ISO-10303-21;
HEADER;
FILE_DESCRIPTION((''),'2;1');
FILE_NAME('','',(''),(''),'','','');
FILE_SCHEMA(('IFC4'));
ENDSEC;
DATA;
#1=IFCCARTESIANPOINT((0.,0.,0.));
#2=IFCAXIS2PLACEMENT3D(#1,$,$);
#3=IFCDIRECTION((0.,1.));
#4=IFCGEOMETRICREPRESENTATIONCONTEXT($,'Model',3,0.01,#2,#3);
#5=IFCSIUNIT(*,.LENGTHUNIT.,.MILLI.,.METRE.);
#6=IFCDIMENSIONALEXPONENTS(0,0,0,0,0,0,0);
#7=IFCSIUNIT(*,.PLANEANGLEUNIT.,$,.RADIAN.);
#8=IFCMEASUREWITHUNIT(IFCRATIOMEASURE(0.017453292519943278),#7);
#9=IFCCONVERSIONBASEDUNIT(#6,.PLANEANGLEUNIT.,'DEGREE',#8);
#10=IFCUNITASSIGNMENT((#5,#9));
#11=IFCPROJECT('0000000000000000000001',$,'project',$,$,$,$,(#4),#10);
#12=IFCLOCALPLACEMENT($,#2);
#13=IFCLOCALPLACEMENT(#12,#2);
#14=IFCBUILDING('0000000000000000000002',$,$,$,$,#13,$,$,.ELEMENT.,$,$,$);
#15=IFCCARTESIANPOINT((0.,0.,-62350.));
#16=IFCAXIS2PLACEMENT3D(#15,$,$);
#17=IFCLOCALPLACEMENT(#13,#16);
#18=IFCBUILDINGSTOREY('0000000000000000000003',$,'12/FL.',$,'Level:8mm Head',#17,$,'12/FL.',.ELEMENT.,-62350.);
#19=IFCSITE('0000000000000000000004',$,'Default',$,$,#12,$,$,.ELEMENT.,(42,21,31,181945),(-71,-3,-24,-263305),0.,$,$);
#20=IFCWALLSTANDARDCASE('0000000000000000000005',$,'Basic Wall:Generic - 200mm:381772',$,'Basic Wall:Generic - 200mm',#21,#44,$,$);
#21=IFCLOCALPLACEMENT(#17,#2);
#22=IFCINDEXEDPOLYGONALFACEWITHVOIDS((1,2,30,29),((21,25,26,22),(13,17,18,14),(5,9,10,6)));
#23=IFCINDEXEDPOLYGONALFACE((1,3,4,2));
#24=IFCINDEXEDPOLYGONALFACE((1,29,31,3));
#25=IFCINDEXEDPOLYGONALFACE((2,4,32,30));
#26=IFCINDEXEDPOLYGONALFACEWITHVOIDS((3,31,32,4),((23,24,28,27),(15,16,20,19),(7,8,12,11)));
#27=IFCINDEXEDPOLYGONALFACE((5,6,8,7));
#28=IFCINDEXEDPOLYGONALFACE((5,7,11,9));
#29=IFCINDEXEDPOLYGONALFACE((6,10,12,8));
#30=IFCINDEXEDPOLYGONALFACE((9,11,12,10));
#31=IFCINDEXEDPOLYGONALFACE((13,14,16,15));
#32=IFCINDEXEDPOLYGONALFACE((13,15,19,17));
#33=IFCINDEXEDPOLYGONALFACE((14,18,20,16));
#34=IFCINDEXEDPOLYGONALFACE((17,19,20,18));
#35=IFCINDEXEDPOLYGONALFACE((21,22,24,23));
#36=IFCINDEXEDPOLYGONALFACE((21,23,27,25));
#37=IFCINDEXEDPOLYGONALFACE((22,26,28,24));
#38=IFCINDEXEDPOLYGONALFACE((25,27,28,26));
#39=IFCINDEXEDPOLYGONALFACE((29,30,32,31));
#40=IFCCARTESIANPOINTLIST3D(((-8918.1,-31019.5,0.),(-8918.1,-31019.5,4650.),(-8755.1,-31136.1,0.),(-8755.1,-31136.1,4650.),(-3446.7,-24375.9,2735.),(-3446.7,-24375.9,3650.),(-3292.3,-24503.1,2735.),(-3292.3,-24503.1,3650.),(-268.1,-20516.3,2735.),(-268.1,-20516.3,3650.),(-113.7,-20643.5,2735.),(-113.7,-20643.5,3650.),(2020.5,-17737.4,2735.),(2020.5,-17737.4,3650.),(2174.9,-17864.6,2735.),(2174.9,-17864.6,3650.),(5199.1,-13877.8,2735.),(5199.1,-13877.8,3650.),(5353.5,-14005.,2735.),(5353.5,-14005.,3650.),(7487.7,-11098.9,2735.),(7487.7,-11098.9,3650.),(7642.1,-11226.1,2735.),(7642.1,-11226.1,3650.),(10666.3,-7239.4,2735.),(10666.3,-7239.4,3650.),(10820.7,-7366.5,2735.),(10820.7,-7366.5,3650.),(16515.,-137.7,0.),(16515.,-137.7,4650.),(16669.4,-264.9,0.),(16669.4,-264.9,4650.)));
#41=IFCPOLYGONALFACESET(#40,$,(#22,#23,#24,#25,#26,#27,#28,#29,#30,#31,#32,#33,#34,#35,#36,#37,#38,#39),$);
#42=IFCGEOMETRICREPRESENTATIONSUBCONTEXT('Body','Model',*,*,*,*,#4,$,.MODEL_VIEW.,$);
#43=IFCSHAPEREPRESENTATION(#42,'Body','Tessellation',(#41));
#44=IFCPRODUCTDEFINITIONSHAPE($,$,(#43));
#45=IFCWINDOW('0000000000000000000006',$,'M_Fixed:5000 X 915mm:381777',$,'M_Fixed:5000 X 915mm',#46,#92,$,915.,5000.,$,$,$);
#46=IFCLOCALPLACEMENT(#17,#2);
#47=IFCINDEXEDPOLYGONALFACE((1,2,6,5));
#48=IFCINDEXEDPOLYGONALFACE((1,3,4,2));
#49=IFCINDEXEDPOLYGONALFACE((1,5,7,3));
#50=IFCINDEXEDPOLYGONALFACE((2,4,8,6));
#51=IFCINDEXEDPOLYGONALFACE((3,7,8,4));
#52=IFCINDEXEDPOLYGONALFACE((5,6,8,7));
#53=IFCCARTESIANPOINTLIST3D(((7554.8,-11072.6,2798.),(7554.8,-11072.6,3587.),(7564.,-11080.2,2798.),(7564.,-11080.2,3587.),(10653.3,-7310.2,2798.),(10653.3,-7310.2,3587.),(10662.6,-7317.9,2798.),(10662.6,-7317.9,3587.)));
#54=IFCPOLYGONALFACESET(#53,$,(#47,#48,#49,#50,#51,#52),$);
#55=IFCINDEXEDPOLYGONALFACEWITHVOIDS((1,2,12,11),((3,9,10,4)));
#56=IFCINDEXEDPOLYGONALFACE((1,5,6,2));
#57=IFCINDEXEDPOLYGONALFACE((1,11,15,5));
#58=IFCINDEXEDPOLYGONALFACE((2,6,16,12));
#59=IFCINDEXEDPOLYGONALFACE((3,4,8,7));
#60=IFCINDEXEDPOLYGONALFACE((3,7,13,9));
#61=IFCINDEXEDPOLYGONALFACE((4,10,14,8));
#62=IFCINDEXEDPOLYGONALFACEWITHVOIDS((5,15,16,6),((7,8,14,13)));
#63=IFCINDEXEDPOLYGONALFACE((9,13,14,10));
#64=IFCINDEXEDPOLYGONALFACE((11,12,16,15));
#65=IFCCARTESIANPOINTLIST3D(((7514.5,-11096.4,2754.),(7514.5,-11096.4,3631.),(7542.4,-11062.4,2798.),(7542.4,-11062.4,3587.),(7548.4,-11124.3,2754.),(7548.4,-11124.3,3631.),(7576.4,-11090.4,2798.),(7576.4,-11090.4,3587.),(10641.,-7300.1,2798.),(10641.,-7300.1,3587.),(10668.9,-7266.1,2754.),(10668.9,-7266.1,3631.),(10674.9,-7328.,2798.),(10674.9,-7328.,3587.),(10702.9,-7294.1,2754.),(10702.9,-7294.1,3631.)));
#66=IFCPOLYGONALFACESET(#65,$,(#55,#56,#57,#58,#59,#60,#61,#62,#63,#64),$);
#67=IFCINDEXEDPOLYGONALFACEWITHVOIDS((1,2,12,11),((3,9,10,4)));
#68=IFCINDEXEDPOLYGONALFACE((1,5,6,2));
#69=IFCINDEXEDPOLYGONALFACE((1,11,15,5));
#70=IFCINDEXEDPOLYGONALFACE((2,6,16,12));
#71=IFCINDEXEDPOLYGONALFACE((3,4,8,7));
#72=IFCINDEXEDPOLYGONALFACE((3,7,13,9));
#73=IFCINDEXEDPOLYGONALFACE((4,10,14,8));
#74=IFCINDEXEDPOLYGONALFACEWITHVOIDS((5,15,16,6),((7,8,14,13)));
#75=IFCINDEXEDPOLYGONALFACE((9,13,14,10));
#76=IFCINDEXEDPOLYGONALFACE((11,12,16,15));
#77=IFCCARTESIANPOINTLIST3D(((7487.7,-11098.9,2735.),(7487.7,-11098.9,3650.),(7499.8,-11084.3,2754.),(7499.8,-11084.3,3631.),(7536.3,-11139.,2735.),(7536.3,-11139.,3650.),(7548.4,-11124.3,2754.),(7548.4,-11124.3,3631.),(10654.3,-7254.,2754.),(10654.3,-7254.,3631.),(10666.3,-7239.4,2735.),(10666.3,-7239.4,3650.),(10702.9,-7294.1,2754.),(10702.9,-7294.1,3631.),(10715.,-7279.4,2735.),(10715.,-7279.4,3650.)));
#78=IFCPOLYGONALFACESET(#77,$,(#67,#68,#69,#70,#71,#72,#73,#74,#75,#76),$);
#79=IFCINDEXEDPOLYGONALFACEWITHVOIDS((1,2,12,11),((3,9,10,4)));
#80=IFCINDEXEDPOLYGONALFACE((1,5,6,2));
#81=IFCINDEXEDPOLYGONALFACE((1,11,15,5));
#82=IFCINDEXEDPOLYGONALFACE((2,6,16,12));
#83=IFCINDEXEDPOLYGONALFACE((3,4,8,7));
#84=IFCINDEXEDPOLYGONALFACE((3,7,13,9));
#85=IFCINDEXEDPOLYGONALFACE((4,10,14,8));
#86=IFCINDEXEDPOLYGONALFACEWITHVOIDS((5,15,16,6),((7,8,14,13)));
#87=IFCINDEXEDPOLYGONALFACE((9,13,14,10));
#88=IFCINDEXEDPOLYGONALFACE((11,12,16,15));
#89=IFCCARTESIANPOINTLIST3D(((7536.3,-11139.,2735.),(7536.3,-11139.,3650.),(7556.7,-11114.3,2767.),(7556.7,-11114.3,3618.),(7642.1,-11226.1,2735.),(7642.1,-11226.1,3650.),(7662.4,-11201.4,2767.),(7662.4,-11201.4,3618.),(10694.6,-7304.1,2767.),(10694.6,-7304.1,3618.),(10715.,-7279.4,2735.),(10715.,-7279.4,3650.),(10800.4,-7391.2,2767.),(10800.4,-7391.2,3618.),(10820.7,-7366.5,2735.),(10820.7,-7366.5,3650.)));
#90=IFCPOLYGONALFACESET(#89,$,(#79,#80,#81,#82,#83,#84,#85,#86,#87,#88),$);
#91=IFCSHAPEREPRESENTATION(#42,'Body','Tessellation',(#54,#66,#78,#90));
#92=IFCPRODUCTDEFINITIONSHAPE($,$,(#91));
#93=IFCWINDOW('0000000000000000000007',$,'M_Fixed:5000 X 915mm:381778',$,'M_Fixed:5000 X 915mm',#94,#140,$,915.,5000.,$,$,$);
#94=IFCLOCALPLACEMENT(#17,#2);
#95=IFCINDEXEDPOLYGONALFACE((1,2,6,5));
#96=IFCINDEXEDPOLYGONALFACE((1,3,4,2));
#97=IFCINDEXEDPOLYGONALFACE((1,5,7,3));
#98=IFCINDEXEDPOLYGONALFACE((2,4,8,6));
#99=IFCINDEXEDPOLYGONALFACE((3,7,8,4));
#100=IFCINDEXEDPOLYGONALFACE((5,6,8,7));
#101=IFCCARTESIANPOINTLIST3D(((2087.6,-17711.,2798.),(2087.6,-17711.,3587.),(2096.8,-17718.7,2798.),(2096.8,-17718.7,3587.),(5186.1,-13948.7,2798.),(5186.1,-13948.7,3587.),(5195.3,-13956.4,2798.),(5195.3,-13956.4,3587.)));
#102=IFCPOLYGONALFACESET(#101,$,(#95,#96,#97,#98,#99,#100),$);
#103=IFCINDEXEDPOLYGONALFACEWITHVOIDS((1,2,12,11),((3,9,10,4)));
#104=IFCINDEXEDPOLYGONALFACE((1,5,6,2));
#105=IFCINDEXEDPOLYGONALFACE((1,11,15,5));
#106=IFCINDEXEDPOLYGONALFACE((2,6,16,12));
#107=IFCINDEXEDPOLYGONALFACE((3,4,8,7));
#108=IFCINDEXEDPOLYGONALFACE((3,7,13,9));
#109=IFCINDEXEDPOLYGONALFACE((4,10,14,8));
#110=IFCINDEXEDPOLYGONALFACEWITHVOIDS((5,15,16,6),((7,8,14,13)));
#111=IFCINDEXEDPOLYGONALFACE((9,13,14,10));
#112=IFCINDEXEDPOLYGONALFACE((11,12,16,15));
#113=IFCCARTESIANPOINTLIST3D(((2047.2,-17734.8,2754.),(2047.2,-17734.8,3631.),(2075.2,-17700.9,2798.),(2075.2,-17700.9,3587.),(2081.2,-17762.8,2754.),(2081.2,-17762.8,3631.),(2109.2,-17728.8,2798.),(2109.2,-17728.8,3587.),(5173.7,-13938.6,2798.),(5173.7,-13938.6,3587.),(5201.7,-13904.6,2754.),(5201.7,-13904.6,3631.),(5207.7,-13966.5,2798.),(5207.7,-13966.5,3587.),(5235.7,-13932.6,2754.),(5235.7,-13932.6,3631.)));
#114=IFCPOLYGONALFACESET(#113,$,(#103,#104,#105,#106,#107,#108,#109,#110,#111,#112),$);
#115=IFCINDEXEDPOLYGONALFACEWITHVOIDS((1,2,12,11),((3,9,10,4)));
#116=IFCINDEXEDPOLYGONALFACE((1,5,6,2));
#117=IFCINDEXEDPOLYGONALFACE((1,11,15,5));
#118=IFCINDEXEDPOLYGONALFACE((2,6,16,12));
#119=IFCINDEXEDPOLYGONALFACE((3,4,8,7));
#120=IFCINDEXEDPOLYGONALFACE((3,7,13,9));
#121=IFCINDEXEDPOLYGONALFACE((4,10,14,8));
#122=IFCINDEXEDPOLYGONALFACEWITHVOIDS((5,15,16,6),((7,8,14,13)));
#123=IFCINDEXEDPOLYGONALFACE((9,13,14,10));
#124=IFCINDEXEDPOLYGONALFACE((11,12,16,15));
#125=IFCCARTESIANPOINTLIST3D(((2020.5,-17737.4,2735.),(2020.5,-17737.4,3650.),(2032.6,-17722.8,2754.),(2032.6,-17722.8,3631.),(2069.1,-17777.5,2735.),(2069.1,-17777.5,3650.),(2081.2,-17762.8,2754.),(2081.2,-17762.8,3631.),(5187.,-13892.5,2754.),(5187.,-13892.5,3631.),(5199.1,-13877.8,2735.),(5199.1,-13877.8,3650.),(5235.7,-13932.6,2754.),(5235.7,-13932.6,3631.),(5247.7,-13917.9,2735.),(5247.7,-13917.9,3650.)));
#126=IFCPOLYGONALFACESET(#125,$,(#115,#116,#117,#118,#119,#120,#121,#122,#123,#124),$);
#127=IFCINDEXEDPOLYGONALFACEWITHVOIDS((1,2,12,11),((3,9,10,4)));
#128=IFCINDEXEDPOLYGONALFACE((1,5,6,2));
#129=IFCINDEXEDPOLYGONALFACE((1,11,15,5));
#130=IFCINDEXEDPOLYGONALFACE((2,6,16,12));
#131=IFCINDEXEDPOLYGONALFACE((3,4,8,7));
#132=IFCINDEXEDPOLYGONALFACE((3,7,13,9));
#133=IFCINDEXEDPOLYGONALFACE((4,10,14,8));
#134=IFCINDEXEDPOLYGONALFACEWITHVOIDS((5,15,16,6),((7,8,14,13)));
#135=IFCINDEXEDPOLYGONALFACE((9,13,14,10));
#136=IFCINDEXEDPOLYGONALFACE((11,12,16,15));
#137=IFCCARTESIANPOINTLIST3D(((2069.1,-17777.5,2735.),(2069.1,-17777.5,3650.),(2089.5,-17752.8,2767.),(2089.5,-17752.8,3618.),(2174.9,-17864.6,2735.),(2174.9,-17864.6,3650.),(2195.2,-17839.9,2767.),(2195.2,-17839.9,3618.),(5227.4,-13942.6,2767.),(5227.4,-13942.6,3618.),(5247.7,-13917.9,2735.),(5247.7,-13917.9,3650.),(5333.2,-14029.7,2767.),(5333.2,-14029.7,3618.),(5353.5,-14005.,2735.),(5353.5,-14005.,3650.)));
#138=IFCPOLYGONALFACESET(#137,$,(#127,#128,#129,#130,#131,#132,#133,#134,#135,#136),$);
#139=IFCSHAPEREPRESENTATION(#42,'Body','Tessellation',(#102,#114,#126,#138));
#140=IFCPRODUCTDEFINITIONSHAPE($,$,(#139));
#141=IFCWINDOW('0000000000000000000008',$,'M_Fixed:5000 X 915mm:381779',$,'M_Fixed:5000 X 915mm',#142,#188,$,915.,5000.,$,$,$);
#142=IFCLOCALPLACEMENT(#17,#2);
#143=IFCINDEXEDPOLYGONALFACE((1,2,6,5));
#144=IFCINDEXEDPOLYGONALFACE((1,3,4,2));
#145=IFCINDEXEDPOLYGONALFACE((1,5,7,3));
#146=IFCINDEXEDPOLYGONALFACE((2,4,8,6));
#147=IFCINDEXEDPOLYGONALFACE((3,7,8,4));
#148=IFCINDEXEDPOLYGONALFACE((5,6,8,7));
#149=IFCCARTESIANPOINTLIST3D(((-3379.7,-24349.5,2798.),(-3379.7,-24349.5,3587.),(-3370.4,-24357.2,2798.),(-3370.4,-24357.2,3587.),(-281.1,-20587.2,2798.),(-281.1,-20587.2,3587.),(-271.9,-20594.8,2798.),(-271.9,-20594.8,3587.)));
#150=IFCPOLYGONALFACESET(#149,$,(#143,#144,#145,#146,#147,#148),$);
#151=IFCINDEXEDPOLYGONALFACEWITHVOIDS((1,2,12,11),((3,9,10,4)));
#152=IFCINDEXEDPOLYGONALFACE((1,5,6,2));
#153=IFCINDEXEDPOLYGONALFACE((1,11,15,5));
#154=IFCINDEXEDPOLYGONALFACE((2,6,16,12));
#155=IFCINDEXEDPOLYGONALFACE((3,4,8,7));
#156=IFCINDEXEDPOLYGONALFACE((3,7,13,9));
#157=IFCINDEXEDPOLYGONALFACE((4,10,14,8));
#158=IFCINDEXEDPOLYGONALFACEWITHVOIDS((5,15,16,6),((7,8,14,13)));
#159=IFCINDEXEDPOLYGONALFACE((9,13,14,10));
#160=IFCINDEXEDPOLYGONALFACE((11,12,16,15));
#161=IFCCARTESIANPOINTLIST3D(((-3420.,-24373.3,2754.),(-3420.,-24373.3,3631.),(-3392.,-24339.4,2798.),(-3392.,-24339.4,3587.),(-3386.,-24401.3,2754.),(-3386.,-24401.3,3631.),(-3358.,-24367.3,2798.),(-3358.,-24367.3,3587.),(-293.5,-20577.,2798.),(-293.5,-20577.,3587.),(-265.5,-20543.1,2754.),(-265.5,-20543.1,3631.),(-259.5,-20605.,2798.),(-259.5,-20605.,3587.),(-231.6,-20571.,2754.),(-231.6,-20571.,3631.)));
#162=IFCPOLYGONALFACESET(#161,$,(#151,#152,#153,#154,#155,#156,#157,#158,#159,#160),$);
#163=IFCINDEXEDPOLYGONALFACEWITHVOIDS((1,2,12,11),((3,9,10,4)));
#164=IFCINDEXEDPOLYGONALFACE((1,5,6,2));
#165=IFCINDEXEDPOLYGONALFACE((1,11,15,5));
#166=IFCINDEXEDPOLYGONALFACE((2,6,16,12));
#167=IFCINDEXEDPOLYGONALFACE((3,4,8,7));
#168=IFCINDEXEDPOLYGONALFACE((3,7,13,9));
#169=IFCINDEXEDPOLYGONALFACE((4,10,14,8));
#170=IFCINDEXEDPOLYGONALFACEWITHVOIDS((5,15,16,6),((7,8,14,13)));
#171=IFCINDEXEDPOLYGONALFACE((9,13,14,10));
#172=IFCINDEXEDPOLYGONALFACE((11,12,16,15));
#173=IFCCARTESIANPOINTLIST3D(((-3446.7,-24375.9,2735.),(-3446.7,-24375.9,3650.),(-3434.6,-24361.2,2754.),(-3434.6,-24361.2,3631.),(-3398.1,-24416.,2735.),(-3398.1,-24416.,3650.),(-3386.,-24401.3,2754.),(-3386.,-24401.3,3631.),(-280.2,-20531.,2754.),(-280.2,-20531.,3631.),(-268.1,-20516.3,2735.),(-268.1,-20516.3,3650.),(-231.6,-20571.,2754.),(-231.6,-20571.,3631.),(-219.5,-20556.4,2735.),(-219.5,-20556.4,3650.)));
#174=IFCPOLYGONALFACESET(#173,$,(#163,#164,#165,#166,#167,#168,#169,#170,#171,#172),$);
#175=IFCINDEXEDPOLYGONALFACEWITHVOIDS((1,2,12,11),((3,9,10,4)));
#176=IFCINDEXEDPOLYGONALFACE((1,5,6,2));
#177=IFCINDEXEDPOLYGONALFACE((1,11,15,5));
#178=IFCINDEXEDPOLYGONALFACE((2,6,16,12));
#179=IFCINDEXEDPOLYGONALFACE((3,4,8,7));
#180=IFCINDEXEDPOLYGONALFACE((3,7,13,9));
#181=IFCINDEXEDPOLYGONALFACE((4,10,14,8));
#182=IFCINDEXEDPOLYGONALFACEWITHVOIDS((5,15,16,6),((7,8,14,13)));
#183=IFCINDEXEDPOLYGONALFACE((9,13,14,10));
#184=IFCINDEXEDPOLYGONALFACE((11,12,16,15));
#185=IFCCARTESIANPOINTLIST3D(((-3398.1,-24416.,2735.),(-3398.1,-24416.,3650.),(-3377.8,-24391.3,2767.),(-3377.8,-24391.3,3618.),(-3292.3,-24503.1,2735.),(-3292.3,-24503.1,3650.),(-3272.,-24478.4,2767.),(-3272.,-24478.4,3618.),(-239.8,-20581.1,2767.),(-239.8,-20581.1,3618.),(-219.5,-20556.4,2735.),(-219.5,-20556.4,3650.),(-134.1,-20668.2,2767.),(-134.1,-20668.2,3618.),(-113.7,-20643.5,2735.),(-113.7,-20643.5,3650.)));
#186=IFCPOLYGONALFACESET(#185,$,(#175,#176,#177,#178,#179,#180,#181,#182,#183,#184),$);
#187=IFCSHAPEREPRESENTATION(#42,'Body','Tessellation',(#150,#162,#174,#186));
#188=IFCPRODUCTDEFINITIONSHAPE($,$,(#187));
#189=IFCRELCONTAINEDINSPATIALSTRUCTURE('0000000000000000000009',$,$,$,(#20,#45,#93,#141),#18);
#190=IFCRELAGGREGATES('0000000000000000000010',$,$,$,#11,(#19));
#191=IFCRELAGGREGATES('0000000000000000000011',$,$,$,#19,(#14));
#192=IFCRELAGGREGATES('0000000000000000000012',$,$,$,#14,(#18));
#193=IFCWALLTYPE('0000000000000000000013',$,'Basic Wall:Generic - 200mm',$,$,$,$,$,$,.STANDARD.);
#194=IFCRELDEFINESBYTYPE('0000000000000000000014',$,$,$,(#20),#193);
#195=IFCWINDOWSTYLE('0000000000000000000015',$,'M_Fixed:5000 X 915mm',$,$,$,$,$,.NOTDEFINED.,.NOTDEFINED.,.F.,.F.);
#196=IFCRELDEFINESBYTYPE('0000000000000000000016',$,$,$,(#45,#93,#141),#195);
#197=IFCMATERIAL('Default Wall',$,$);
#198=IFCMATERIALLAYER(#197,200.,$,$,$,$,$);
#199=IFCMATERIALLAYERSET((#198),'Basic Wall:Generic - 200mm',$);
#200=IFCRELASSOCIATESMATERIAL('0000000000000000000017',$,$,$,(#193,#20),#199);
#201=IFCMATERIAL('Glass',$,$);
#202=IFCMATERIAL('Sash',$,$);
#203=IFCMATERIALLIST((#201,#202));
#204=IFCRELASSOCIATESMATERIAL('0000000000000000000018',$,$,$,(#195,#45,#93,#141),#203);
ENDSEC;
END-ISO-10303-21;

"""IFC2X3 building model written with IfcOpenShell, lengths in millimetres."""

from ifc_helpers import new_model, entity, si_unit, converted_unit, direction, frame, frame_2d, origin, place, context, subcontext, project, spatial, polyline, rectangle, outline, extrude, source, transform, mapped, material, material_list, layer, layer_set, layer_usage, type_object, type_shapes, element, fill, save


model = new_model("IFC2X3")

# Units and contexts
model_context = context("Model", 3, precision=0.01, world=origin(), true_north=direction((0.0, 1.0)))
body_context = subcontext(model_context, "Body", "Model", "MODEL_VIEW")
ifc_project = project(units=[si_unit("LENGTHUNIT", "METRE", prefix="MILLI"), converted_unit("PLANEANGLEUNIT", "DEGREE", entity("IfcRatioMeasure", 0.017453292519943278), si_unit("PLANEANGLEUNIT", "RADIAN"), dimensions=[0, 0, 0, 0, 0, 0, 0])], contexts=[model_context])

# Site, building, storey
site_placement = place(None, origin())
site = spatial("IfcSite", under=ifc_project, at=site_placement, Name="Default", CompositionType="ELEMENT", RefLatitude=(42, 21, 31, 181945), RefLongitude=(-71, -3, -24, -263305), RefElevation=0.0)
building_placement = place(site_placement, origin())
building = spatial("IfcBuilding", under=site, at=building_placement, CompositionType="ELEMENT")
storey_placement = place(building_placement, frame((0.0, 0.0, -62350.0)))
storey = spatial("IfcBuildingStorey", under=building, at=storey_placement, Name="12/FL.", ObjectType="Level:8mm Head", LongName="12/FL.", CompositionType="ELEMENT", Elevation=-62350.0)

# Shared definitions
ifc_material_1 = material(Name="Default Wall")
ifc_layer = layer(ifc_material_1, 200.0)
ifc_layer_set = layer_set([ifc_layer], Name="Basic Wall:Generic - 200mm")
ifc_layer_usage = layer_usage(ifc_layer_set, "AXIS2", "NEGATIVE", 100.0)
wall_type = type_object("IfcWallType", Name="Basic Wall:Generic - 200mm", PredefinedType="STANDARD", material=ifc_layer_set)

# Wall, openings, windows
wall_1_placement = place(storey_placement, frame((17100.8, 416.2, 0.0), z_axis=(0.0, 0.0, 1.0), x_axis=(-0.635723, -0.771917, 0.0)))
wall_1 = element("IfcWallStandardCase", 1, at=wall_1_placement, inside=storey, type_object=wall_type, material=ifc_layer_usage, Name="Basic Wall:Generic - 200mm:381772", ObjectType="Basic Wall:Generic - 200mm", context=body_context, shape_type="SweptSolid", body=[
    extrude(outline(polyline([(40806.5, -100.0), (40793.0, 100.0), (37219.3, 100.0), (37019.3, 100.0), (800.0, 100.0), (800.0, -100.0), (37019.3, -100.0), (37219.3, -100.0), (40806.5, -100.0)])), origin(), (0.0, 0.0, 1.0), 4650.0),
])
opening_1_placement = place(wall_1_placement, origin())
element("IfcOpeningElement", 2, at=opening_1_placement, cuts=wall_1, ObjectType="Opening", context=body_context, shape_type="SweptSolid", body=[
    extrude(rectangle(XDim=1000.0, YDim=1012.7, at=frame_2d((0.0, 0.0), x_axis=(1.0, 0.0))), frame((293.7, -183.3, 500.0), z_axis=(0.0, 1.0, 0.0), x_axis=(0.0, 0.0, -1.0)), (0.0, 0.0, 1.0), 1010.1),
])
opening_2_placement = place(wall_1_placement, frame((15000.0, 100.0, 2735.0)))
opening_2 = element("IfcOpeningElement", 3, at=opening_2_placement, cuts=wall_1, ObjectType="Opening", context=body_context, shape_type="SweptSolid", body=[
    extrude(rectangle(XDim=915.0, YDim=5000.0, at=frame_2d((457.5, 2500.0), x_axis=(1.0, 0.0))), frame((0.0, 0.0, 0.0), z_axis=(0.0, -1.0, 0.0), x_axis=(0.0, 0.0, 1.0)), (0.0, 0.0, 1.0), 200.0),
])
opening_3_placement = place(wall_1_placement, frame((23600.0, 100.0, 2735.0)))
opening_3 = element("IfcOpeningElement", 4, at=opening_3_placement, cuts=wall_1, ObjectType="Opening", context=body_context, shape_type="SweptSolid", body=[
    extrude(rectangle(XDim=915.0, YDim=5000.0, at=frame_2d((457.5, 2500.0), x_axis=(1.0, 0.0))), frame((0.0, 0.0, 0.0), z_axis=(0.0, -1.0, 0.0), x_axis=(0.0, 0.0, 1.0)), (0.0, 0.0, 1.0), 200.0),
])
opening_4_placement = place(wall_1_placement, frame((32200.0, 100.0, 2735.0)))
opening_4 = element("IfcOpeningElement", 5, at=opening_4_placement, cuts=wall_1, ObjectType="Opening", context=body_context, shape_type="SweptSolid", body=[
    extrude(rectangle(XDim=915.0, YDim=5000.0, at=frame_2d((457.5, 2500.0), x_axis=(1.0, 0.0))), frame((0.0, 0.0, 0.0), z_axis=(0.0, -1.0, 0.0), x_axis=(0.0, 0.0, 1.0)), (0.0, 0.0, 1.0), 200.0),
])
ifc_material_2 = material(Name="Glass")
ifc_material_3 = material(Name="Sash")
ifc_material_list = material_list([ifc_material_2, ifc_material_3])
window_style_1 = type_object("IfcWindowStyle", Name="M_Fixed:5000 X 915mm", ConstructionType="NOTDEFINED", OperationType="NOTDEFINED", ParameterTakesPrecedence=False, Sizeable=False, material=ifc_material_list)
shared_shape_1 = source(origin(), body_context, "Body", "SweptSolid", [
    extrude(rectangle(XDim=12.0, YDim=4874.0, at=frame_2d((0.0, 0.0), x_axis=(1.0, 0.0))), frame((2500.0, 159.0, 63.0), z_axis=(0.0, 0.0, 1.0), x_axis=(0.0, -1.0, 0.0)), (0.0, 0.0, 1.0), 789.0),
    extrude(outline(polyline([(-2481.0, -438.5), (2481.0, -438.5), (2481.0, 438.5), (-2481.0, 438.5), (-2481.0, -438.5)]), holes=[polyline([(-2437.0, -394.5), (-2437.0, 394.5), (2437.0, 394.5), (2437.0, -394.5), (-2437.0, -394.5)])]), frame((2500.0, 137.0, 457.5), z_axis=(0.0, 1.0, 0.0), x_axis=(1.0, 0.0, 0.0)), (0.0, 0.0, 1.0), 44.0),
    extrude(outline(polyline([(-2500.0, -457.5), (2500.0, -457.5), (2500.0, 457.5), (-2500.0, 457.5), (-2500.0, -457.5)]), holes=[polyline([(-2481.0, -438.5), (-2481.0, 438.5), (2481.0, 438.5), (2481.0, -438.5), (-2481.0, -438.5)])]), frame((2500.0, 137.0, 457.5), z_axis=(0.0, 1.0, 0.0), x_axis=(1.0, 0.0, 0.0)), (0.0, 0.0, 1.0), 63.0),
    extrude(outline(polyline([(-2500.0, -457.5), (2500.0, -457.5), (2500.0, 457.5), (-2500.0, 457.5), (-2500.0, -457.5)]), holes=[polyline([(-2468.0, -425.5), (-2468.0, 425.5), (2468.0, 425.5), (2468.0, -425.5), (-2468.0, -425.5)])]), frame((2500.0, 0.0, 457.5), z_axis=(0.0, 1.0, 0.0), x_axis=(1.0, 0.0, 0.0)), (0.0, 0.0, 1.0), 137.0),
])
type_shapes(window_style_1, [shared_shape_1])
window_1_placement = place(opening_2_placement, frame((0.0, 0.0, 0.0), z_axis=(0.0, 0.0, 1.0), x_axis=(-1.0, 0.0, 0.0)))
window_1 = element("IfcWindow", 6, at=window_1_placement, inside=storey, type_object=window_style_1, material=ifc_material_list, Name="M_Fixed:5000 X 915mm:381777", ObjectType="M_Fixed:5000 X 915mm", OverallHeight=915.0, OverallWidth=5000.0, context=body_context, shape_type="MappedRepresentation", body=[
    mapped(shared_shape_1, transform((0.0, 0.0, 0.0), scale=1.0)),
])
fill(opening_2, window_1)
window_2_placement = place(opening_3_placement, frame((0.0, 0.0, 0.0), z_axis=(0.0, 0.0, 1.0), x_axis=(-1.0, 0.0, 0.0)))
window_2 = element("IfcWindow", 7, at=window_2_placement, inside=storey, type_object=window_style_1, material=ifc_material_list, Name="M_Fixed:5000 X 915mm:381778", ObjectType="M_Fixed:5000 X 915mm", OverallHeight=915.0, OverallWidth=5000.0, context=body_context, shape_type="MappedRepresentation", body=[
    mapped(shared_shape_1, transform((0.0, 0.0, 0.0), scale=1.0)),
])
fill(opening_3, window_2)
window_3_placement = place(opening_4_placement, frame((0.0, 0.0, 0.0), z_axis=(0.0, 0.0, 1.0), x_axis=(-1.0, 0.0, 0.0)))
window_3 = element("IfcWindow", 8, at=window_3_placement, inside=storey, type_object=window_style_1, material=ifc_material_list, Name="M_Fixed:5000 X 915mm:381779", ObjectType="M_Fixed:5000 X 915mm", OverallHeight=915.0, OverallWidth=5000.0, context=body_context, shape_type="MappedRepresentation", body=[
    mapped(shared_shape_1, transform((0.0, 0.0, 0.0), scale=1.0)),
])
fill(opening_4, window_3)

save(model, "model.ifc")
